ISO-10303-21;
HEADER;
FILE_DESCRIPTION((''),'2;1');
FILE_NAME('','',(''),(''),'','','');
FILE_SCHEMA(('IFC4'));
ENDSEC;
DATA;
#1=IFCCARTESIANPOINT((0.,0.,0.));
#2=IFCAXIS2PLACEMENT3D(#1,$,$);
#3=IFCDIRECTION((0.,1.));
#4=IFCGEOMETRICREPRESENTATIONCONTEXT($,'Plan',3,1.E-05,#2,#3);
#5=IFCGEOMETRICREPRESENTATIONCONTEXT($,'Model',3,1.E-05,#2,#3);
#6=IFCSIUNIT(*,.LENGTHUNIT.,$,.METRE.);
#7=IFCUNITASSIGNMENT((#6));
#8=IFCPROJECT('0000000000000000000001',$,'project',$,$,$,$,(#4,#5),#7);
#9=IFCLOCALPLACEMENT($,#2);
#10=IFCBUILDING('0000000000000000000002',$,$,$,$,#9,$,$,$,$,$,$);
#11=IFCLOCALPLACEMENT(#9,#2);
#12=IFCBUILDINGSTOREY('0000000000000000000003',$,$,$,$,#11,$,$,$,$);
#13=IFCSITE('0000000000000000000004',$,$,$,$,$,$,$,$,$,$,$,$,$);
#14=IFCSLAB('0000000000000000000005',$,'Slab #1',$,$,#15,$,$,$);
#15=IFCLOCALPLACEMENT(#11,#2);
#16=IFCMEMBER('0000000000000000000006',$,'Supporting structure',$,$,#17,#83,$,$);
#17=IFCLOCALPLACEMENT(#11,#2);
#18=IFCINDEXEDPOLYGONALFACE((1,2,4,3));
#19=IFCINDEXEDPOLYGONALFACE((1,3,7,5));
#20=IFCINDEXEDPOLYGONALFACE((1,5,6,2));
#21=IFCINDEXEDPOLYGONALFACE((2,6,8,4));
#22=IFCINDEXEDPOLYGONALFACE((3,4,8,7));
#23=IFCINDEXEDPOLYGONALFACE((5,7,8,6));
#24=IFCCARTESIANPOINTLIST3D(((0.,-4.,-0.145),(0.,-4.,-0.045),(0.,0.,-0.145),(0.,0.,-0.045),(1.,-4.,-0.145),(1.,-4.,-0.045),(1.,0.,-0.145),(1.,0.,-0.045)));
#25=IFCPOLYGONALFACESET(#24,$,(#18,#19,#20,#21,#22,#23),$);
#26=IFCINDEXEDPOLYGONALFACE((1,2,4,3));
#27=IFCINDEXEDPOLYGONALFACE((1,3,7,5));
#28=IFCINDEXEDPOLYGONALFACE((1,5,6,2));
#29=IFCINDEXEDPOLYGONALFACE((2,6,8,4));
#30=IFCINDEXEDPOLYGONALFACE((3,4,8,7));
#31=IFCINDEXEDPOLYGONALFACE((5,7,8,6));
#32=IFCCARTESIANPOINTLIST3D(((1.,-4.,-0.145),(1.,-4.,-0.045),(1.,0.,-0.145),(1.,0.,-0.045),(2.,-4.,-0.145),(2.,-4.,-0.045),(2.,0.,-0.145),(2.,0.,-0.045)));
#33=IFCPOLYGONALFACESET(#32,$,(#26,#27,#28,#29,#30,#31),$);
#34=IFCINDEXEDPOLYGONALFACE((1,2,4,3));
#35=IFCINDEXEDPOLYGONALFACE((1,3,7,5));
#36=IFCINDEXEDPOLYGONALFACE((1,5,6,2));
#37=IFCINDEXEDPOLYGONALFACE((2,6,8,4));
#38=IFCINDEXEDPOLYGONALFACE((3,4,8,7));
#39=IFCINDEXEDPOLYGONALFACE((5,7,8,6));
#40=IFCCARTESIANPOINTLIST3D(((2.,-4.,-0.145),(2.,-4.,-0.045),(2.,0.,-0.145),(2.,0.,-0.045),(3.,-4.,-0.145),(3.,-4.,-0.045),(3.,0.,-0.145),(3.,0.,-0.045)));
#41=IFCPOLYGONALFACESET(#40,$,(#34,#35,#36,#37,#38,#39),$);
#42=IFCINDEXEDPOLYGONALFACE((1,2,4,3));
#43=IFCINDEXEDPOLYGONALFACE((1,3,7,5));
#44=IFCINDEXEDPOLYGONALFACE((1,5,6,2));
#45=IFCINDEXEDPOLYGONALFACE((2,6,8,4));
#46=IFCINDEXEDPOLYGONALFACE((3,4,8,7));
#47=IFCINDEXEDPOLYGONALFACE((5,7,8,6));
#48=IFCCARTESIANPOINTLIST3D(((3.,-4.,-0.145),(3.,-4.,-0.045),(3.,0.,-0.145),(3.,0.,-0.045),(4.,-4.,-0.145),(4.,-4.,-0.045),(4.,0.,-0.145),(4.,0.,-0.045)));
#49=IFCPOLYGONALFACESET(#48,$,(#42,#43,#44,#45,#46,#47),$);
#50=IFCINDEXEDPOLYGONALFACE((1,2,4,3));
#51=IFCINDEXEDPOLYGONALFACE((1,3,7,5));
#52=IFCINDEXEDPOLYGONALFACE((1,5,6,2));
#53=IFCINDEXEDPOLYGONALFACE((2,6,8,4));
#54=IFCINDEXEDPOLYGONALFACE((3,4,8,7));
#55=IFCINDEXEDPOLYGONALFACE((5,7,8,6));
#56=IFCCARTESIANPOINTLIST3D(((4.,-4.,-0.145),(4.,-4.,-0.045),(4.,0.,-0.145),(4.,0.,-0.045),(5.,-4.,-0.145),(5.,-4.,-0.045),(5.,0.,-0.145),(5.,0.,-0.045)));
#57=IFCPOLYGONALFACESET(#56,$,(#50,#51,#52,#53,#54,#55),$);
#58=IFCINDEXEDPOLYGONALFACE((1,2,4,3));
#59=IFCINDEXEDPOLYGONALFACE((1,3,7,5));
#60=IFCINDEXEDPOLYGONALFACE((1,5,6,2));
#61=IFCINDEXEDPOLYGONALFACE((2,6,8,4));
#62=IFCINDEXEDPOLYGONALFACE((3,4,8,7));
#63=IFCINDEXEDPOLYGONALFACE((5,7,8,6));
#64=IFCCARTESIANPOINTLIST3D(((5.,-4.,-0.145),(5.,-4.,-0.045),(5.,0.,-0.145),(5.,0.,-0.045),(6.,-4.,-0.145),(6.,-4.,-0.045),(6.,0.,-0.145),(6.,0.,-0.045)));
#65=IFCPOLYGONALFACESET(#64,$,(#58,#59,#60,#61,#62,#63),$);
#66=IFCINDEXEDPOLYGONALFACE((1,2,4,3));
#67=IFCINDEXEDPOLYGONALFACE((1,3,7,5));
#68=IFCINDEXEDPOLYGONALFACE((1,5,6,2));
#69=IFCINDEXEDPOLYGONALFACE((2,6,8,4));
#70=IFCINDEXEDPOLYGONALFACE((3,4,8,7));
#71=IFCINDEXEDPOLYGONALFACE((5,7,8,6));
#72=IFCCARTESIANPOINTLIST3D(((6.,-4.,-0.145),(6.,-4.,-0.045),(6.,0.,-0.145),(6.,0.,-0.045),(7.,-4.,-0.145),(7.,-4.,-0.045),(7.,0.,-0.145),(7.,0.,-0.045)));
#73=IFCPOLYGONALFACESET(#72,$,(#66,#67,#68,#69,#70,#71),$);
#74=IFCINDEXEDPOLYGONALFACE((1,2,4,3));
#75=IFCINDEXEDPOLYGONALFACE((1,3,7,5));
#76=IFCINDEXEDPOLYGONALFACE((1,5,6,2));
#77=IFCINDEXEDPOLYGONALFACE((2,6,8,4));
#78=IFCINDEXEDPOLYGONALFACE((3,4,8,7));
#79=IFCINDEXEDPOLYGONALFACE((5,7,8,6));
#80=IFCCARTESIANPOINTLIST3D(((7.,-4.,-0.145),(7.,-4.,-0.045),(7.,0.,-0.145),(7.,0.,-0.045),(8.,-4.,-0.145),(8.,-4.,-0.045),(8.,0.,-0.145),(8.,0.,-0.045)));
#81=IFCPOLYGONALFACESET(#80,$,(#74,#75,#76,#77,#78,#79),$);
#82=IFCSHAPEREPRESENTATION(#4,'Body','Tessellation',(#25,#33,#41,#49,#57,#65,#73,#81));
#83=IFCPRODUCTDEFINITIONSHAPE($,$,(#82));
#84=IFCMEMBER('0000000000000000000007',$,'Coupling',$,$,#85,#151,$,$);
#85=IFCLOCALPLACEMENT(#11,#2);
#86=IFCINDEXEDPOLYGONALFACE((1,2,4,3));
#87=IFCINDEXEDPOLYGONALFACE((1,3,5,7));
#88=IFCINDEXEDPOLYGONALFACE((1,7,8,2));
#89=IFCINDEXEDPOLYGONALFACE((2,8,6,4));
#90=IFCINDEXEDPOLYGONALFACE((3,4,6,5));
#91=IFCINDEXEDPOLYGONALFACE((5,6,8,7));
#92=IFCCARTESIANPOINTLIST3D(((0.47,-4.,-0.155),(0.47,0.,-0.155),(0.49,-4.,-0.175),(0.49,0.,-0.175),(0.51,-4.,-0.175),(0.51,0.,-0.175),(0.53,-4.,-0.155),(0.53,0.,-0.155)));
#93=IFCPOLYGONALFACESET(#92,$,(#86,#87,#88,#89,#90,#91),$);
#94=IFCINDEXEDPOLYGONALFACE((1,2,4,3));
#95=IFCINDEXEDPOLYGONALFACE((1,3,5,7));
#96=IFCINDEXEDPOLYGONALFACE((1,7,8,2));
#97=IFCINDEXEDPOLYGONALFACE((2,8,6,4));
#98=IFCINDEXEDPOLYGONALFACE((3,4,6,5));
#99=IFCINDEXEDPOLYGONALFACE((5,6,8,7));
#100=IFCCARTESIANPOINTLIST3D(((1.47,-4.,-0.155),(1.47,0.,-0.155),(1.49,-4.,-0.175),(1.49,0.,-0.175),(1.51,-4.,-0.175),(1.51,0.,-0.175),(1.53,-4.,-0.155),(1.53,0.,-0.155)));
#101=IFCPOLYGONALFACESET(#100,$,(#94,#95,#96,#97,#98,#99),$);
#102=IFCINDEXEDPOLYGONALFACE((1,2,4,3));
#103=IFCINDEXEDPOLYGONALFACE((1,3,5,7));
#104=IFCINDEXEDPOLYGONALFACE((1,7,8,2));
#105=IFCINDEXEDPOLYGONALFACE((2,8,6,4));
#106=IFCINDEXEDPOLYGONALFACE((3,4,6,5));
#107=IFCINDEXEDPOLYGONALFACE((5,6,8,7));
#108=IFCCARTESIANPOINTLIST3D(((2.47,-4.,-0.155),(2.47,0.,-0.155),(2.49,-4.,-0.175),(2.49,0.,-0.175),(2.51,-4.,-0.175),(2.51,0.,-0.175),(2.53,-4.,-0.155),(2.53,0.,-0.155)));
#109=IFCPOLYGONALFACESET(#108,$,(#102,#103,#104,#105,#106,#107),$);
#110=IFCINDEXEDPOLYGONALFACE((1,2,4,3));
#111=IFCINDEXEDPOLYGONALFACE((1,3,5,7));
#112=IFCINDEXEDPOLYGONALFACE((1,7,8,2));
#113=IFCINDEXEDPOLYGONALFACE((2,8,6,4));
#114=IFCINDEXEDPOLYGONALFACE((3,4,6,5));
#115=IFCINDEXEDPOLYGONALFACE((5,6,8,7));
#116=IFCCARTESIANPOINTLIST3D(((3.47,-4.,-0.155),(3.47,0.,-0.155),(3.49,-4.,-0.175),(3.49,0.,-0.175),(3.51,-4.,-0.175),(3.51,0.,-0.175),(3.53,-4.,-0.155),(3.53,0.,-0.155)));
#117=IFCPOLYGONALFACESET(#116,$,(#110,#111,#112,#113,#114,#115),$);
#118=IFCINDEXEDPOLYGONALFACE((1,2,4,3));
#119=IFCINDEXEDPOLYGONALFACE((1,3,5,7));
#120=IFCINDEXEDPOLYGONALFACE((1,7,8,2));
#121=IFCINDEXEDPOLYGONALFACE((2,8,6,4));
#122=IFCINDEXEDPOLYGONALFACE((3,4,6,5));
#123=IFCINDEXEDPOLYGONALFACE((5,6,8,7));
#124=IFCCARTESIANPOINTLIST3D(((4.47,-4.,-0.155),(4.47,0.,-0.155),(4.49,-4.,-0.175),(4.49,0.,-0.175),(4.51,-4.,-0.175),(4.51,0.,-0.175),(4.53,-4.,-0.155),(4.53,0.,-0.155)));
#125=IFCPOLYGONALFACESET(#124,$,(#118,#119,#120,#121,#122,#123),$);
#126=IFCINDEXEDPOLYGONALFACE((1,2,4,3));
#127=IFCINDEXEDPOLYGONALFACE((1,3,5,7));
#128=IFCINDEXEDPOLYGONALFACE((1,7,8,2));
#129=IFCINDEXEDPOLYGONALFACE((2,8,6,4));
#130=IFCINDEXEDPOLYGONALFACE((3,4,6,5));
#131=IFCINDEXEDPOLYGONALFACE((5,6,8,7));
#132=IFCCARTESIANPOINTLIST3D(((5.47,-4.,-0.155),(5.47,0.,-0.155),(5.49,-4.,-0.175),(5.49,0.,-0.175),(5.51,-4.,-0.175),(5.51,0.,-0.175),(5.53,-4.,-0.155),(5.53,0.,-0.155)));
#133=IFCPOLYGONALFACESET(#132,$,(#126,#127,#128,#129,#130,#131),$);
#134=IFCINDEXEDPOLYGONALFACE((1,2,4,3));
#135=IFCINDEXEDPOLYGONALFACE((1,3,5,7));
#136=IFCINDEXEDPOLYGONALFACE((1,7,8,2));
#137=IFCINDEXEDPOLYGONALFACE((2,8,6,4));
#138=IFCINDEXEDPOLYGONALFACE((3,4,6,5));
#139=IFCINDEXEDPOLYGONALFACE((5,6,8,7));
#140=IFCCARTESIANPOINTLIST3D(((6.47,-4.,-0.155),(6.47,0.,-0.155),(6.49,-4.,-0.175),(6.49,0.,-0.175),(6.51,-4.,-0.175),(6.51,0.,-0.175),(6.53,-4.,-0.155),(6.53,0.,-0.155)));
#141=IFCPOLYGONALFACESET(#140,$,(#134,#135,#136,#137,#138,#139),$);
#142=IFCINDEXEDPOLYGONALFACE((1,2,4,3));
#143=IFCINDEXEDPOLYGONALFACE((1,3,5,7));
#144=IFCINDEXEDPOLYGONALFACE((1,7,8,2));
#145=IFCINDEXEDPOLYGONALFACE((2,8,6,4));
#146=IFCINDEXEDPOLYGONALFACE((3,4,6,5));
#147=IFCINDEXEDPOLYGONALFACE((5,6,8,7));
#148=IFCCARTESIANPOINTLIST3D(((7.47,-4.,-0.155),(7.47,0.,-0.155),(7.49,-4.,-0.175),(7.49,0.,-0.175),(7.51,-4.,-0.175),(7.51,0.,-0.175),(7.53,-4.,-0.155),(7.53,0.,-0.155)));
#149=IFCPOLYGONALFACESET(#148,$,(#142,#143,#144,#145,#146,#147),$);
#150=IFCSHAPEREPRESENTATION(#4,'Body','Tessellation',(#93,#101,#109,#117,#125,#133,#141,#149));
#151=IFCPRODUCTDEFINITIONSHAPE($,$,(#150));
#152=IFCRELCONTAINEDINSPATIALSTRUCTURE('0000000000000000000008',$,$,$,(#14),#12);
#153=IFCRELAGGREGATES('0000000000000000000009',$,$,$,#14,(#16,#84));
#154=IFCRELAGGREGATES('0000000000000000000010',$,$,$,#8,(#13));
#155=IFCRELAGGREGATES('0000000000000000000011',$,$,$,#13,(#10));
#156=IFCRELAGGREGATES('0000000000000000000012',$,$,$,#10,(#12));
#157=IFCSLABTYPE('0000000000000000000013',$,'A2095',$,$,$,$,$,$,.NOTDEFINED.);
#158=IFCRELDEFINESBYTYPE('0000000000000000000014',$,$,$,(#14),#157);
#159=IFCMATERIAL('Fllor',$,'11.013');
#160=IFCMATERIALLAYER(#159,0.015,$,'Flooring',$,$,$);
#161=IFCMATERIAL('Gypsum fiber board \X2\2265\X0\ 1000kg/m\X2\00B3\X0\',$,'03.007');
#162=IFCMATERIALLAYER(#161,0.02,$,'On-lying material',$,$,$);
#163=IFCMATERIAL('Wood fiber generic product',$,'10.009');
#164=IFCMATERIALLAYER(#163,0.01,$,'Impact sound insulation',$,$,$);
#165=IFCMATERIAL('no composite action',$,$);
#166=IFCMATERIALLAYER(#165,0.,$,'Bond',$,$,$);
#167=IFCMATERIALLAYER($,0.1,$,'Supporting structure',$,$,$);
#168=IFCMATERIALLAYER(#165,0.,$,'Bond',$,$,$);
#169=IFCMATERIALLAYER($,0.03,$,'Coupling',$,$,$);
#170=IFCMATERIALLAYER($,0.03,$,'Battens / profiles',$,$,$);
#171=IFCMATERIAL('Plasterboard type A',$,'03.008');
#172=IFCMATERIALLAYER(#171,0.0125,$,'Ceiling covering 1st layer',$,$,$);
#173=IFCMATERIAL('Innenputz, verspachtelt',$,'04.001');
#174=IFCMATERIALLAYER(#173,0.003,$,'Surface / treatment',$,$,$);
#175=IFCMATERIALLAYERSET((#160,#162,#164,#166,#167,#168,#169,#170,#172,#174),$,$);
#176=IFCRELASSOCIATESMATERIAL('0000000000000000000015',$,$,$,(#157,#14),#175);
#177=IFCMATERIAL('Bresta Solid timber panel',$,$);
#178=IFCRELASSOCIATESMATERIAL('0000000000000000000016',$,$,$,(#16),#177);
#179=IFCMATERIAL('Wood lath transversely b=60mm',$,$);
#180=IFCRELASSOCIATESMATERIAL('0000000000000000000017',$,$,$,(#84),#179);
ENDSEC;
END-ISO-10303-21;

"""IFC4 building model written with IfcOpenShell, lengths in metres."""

from ifc_helpers import new_model, si_unit, direction, frame, frame_2d, origin, place, context, project, spatial, polyline, rectangle, outline, extrude, material, layer, layer_set, type_object, element, aggregate, save


model = new_model("IFC4")

# Units and contexts
plan_context = context("Plan", 3, precision=1e-05, world=origin(), true_north=direction((0.0, 1.0)))
model_context = context("Model", 3, precision=1e-05, world=origin(), true_north=direction((0.0, 1.0)))
ifc_project = project(units=[si_unit("LENGTHUNIT", "METRE")], contexts=[plan_context, model_context])

# Site, building, storey
site = spatial("IfcSite", under=ifc_project)
building_placement = place(None, origin())
building = spatial("IfcBuilding", under=site, at=building_placement)
storey_placement = place(building_placement, origin())
storey = spatial("IfcBuildingStorey", under=building, at=storey_placement)

# Slab, members
ifc_material_1 = material(Name="Fllor", Category="11.013")
ifc_layer_1 = layer(ifc_material_1, 0.015, Name="Flooring")
ifc_material_2 = material(Name="Gypsum fiber board ≥ 1000kg/m³", Category="03.007")
ifc_layer_2 = layer(ifc_material_2, 0.02, Name="On-lying material")
ifc_material_3 = material(Name="Wood fiber generic product", Category="10.009")
ifc_layer_3 = layer(ifc_material_3, 0.01, Name="Impact sound insulation")
ifc_material_4 = material(Name="no composite action")
ifc_layer_4 = layer(ifc_material_4, 0.0, Name="Bond")
ifc_layer_5 = layer(None, 0.1, Name="Supporting structure")
ifc_layer_6 = layer(ifc_material_4, 0.0, Name="Bond")
ifc_layer_7 = layer(None, 0.03, Name="Coupling")
ifc_layer_8 = layer(None, 0.03, Name="Battens / profiles")
ifc_material_5 = material(Name="Plasterboard type A", Category="03.008")
ifc_layer_9 = layer(ifc_material_5, 0.0125, Name="Ceiling covering 1st layer")
ifc_material_6 = material(Name="Innenputz, verspachtelt", Category="04.001")
ifc_layer_10 = layer(ifc_material_6, 0.003, Name="Surface / treatment")
ifc_layer_set = layer_set([ifc_layer_1, ifc_layer_2, ifc_layer_3, ifc_layer_4, ifc_layer_5, ifc_layer_6, ifc_layer_7, ifc_layer_8, ifc_layer_9, ifc_layer_10])
slab_type = type_object("IfcSlabType", Name="A2095", PredefinedType="NOTDEFINED", material=ifc_layer_set)
slab_placement = place(None, frame((0.0, 0.0, 0.0), z_axis=(0.0, 0.0, -1.0), x_axis=(1.0, 0.0, 0.0)))
slab = element("IfcSlab", 1, at=slab_placement, inside=storey, type_object=slab_type, material=ifc_layer_set, Name="Slab #1")
ifc_material_7 = material(Name="Bresta Solid timber panel")
member_1_placement = place(slab_placement, origin())
member_1 = element("IfcMember", 2, at=member_1_placement, material=ifc_material_7, Name="Supporting structure", context=plan_context, shape_type="SweptSolid", body=[
    extrude(rectangle(XDim=1.0, YDim=0.1, at=frame_2d((0.5, 0.05), x_axis=(1.0, 0.0))), frame((0.0, 4.0, 0.045), z_axis=(0.0, -1.0, 0.0), x_axis=(1.0, 0.0, 0.0)), (0.0, 0.0, 1.0), 4.0),
    extrude(rectangle(XDim=1.0, YDim=0.1, at=frame_2d((0.5, 0.05), x_axis=(1.0, 0.0))), frame((1.0, 4.0, 0.045), z_axis=(0.0, -1.0, 0.0), x_axis=(1.0, 0.0, 0.0)), (0.0, 0.0, 1.0), 4.0),
    extrude(rectangle(XDim=1.0, YDim=0.1, at=frame_2d((0.5, 0.05), x_axis=(1.0, 0.0))), frame((2.0, 4.0, 0.045), z_axis=(0.0, -1.0, 0.0), x_axis=(1.0, 0.0, 0.0)), (0.0, 0.0, 1.0), 4.0),
    extrude(rectangle(XDim=1.0, YDim=0.1, at=frame_2d((0.5, 0.05), x_axis=(1.0, 0.0))), frame((3.0, 4.0, 0.045), z_axis=(0.0, -1.0, 0.0), x_axis=(1.0, 0.0, 0.0)), (0.0, 0.0, 1.0), 4.0),
    extrude(rectangle(XDim=1.0, YDim=0.1, at=frame_2d((0.5, 0.05), x_axis=(1.0, 0.0))), frame((4.0, 4.0, 0.045), z_axis=(0.0, -1.0, 0.0), x_axis=(1.0, 0.0, 0.0)), (0.0, 0.0, 1.0), 4.0),
    extrude(rectangle(XDim=1.0, YDim=0.1, at=frame_2d((0.5, 0.05), x_axis=(1.0, 0.0))), frame((5.0, 4.0, 0.045), z_axis=(0.0, -1.0, 0.0), x_axis=(1.0, 0.0, 0.0)), (0.0, 0.0, 1.0), 4.0),
    extrude(rectangle(XDim=1.0, YDim=0.1, at=frame_2d((0.5, 0.05), x_axis=(1.0, 0.0))), frame((6.0, 4.0, 0.045), z_axis=(0.0, -1.0, 0.0), x_axis=(1.0, 0.0, 0.0)), (0.0, 0.0, 1.0), 4.0),
    extrude(rectangle(XDim=1.0, YDim=0.1, at=frame_2d((0.5, 0.05), x_axis=(1.0, 0.0))), frame((7.0, 4.0, 0.045), z_axis=(0.0, -1.0, 0.0), x_axis=(1.0, 0.0, 0.0)), (0.0, 0.0, 1.0), 4.0),
])
ifc_material_8 = material(Name="Wood lath transversely b=60mm")
member_2_placement = place(slab_placement, origin())
member_2 = element("IfcMember", 3, at=member_2_placement, material=ifc_material_8, Name="Coupling", context=plan_context, shape_type="SweptSolid", body=[
    extrude(outline(polyline([(0.0, 0.0), (0.06, 0.0), (0.04, 0.02), (0.02, 0.02), (0.0, 0.0)])), frame((0.47, 4.0, 0.155), z_axis=(0.0, -1.0, 0.0), x_axis=(1.0, 0.0, 0.0)), (0.0, 0.0, 1.0), 4.0),
    extrude(outline(polyline([(0.0, 0.0), (0.06, 0.0), (0.04, 0.02), (0.02, 0.02), (0.0, 0.0)])), frame((1.47, 4.0, 0.155), z_axis=(0.0, -1.0, 0.0), x_axis=(1.0, 0.0, 0.0)), (0.0, 0.0, 1.0), 4.0),
    extrude(outline(polyline([(0.0, 0.0), (0.06, 0.0), (0.04, 0.02), (0.02, 0.02), (0.0, 0.0)])), frame((2.47, 4.0, 0.155), z_axis=(0.0, -1.0, 0.0), x_axis=(1.0, 0.0, 0.0)), (0.0, 0.0, 1.0), 4.0),
    extrude(outline(polyline([(0.0, 0.0), (0.06, 0.0), (0.04, 0.02), (0.02, 0.02), (0.0, 0.0)])), frame((3.47, 4.0, 0.155), z_axis=(0.0, -1.0, 0.0), x_axis=(1.0, 0.0, 0.0)), (0.0, 0.0, 1.0), 4.0),
    extrude(outline(polyline([(0.0, 0.0), (0.06, 0.0), (0.04, 0.02), (0.02, 0.02), (0.0, 0.0)])), frame((4.47, 4.0, 0.155), z_axis=(0.0, -1.0, 0.0), x_axis=(1.0, 0.0, 0.0)), (0.0, 0.0, 1.0), 4.0),
    extrude(outline(polyline([(0.0, 0.0), (0.06, 0.0), (0.04, 0.02), (0.02, 0.02), (0.0, 0.0)])), frame((5.47, 4.0, 0.155), z_axis=(0.0, -1.0, 0.0), x_axis=(1.0, 0.0, 0.0)), (0.0, 0.0, 1.0), 4.0),
    extrude(outline(polyline([(0.0, 0.0), (0.06, 0.0), (0.04, 0.02), (0.02, 0.02), (0.0, 0.0)])), frame((6.47, 4.0, 0.155), z_axis=(0.0, -1.0, 0.0), x_axis=(1.0, 0.0, 0.0)), (0.0, 0.0, 1.0), 4.0),
    extrude(outline(polyline([(0.0, 0.0), (0.06, 0.0), (0.04, 0.02), (0.02, 0.02), (0.0, 0.0)])), frame((7.47, 4.0, 0.155), z_axis=(0.0, -1.0, 0.0), x_axis=(1.0, 0.0, 0.0)), (0.0, 0.0, 1.0), 4.0),
])
aggregate(slab, [member_1, member_2])

save(model, "model.ifc")
